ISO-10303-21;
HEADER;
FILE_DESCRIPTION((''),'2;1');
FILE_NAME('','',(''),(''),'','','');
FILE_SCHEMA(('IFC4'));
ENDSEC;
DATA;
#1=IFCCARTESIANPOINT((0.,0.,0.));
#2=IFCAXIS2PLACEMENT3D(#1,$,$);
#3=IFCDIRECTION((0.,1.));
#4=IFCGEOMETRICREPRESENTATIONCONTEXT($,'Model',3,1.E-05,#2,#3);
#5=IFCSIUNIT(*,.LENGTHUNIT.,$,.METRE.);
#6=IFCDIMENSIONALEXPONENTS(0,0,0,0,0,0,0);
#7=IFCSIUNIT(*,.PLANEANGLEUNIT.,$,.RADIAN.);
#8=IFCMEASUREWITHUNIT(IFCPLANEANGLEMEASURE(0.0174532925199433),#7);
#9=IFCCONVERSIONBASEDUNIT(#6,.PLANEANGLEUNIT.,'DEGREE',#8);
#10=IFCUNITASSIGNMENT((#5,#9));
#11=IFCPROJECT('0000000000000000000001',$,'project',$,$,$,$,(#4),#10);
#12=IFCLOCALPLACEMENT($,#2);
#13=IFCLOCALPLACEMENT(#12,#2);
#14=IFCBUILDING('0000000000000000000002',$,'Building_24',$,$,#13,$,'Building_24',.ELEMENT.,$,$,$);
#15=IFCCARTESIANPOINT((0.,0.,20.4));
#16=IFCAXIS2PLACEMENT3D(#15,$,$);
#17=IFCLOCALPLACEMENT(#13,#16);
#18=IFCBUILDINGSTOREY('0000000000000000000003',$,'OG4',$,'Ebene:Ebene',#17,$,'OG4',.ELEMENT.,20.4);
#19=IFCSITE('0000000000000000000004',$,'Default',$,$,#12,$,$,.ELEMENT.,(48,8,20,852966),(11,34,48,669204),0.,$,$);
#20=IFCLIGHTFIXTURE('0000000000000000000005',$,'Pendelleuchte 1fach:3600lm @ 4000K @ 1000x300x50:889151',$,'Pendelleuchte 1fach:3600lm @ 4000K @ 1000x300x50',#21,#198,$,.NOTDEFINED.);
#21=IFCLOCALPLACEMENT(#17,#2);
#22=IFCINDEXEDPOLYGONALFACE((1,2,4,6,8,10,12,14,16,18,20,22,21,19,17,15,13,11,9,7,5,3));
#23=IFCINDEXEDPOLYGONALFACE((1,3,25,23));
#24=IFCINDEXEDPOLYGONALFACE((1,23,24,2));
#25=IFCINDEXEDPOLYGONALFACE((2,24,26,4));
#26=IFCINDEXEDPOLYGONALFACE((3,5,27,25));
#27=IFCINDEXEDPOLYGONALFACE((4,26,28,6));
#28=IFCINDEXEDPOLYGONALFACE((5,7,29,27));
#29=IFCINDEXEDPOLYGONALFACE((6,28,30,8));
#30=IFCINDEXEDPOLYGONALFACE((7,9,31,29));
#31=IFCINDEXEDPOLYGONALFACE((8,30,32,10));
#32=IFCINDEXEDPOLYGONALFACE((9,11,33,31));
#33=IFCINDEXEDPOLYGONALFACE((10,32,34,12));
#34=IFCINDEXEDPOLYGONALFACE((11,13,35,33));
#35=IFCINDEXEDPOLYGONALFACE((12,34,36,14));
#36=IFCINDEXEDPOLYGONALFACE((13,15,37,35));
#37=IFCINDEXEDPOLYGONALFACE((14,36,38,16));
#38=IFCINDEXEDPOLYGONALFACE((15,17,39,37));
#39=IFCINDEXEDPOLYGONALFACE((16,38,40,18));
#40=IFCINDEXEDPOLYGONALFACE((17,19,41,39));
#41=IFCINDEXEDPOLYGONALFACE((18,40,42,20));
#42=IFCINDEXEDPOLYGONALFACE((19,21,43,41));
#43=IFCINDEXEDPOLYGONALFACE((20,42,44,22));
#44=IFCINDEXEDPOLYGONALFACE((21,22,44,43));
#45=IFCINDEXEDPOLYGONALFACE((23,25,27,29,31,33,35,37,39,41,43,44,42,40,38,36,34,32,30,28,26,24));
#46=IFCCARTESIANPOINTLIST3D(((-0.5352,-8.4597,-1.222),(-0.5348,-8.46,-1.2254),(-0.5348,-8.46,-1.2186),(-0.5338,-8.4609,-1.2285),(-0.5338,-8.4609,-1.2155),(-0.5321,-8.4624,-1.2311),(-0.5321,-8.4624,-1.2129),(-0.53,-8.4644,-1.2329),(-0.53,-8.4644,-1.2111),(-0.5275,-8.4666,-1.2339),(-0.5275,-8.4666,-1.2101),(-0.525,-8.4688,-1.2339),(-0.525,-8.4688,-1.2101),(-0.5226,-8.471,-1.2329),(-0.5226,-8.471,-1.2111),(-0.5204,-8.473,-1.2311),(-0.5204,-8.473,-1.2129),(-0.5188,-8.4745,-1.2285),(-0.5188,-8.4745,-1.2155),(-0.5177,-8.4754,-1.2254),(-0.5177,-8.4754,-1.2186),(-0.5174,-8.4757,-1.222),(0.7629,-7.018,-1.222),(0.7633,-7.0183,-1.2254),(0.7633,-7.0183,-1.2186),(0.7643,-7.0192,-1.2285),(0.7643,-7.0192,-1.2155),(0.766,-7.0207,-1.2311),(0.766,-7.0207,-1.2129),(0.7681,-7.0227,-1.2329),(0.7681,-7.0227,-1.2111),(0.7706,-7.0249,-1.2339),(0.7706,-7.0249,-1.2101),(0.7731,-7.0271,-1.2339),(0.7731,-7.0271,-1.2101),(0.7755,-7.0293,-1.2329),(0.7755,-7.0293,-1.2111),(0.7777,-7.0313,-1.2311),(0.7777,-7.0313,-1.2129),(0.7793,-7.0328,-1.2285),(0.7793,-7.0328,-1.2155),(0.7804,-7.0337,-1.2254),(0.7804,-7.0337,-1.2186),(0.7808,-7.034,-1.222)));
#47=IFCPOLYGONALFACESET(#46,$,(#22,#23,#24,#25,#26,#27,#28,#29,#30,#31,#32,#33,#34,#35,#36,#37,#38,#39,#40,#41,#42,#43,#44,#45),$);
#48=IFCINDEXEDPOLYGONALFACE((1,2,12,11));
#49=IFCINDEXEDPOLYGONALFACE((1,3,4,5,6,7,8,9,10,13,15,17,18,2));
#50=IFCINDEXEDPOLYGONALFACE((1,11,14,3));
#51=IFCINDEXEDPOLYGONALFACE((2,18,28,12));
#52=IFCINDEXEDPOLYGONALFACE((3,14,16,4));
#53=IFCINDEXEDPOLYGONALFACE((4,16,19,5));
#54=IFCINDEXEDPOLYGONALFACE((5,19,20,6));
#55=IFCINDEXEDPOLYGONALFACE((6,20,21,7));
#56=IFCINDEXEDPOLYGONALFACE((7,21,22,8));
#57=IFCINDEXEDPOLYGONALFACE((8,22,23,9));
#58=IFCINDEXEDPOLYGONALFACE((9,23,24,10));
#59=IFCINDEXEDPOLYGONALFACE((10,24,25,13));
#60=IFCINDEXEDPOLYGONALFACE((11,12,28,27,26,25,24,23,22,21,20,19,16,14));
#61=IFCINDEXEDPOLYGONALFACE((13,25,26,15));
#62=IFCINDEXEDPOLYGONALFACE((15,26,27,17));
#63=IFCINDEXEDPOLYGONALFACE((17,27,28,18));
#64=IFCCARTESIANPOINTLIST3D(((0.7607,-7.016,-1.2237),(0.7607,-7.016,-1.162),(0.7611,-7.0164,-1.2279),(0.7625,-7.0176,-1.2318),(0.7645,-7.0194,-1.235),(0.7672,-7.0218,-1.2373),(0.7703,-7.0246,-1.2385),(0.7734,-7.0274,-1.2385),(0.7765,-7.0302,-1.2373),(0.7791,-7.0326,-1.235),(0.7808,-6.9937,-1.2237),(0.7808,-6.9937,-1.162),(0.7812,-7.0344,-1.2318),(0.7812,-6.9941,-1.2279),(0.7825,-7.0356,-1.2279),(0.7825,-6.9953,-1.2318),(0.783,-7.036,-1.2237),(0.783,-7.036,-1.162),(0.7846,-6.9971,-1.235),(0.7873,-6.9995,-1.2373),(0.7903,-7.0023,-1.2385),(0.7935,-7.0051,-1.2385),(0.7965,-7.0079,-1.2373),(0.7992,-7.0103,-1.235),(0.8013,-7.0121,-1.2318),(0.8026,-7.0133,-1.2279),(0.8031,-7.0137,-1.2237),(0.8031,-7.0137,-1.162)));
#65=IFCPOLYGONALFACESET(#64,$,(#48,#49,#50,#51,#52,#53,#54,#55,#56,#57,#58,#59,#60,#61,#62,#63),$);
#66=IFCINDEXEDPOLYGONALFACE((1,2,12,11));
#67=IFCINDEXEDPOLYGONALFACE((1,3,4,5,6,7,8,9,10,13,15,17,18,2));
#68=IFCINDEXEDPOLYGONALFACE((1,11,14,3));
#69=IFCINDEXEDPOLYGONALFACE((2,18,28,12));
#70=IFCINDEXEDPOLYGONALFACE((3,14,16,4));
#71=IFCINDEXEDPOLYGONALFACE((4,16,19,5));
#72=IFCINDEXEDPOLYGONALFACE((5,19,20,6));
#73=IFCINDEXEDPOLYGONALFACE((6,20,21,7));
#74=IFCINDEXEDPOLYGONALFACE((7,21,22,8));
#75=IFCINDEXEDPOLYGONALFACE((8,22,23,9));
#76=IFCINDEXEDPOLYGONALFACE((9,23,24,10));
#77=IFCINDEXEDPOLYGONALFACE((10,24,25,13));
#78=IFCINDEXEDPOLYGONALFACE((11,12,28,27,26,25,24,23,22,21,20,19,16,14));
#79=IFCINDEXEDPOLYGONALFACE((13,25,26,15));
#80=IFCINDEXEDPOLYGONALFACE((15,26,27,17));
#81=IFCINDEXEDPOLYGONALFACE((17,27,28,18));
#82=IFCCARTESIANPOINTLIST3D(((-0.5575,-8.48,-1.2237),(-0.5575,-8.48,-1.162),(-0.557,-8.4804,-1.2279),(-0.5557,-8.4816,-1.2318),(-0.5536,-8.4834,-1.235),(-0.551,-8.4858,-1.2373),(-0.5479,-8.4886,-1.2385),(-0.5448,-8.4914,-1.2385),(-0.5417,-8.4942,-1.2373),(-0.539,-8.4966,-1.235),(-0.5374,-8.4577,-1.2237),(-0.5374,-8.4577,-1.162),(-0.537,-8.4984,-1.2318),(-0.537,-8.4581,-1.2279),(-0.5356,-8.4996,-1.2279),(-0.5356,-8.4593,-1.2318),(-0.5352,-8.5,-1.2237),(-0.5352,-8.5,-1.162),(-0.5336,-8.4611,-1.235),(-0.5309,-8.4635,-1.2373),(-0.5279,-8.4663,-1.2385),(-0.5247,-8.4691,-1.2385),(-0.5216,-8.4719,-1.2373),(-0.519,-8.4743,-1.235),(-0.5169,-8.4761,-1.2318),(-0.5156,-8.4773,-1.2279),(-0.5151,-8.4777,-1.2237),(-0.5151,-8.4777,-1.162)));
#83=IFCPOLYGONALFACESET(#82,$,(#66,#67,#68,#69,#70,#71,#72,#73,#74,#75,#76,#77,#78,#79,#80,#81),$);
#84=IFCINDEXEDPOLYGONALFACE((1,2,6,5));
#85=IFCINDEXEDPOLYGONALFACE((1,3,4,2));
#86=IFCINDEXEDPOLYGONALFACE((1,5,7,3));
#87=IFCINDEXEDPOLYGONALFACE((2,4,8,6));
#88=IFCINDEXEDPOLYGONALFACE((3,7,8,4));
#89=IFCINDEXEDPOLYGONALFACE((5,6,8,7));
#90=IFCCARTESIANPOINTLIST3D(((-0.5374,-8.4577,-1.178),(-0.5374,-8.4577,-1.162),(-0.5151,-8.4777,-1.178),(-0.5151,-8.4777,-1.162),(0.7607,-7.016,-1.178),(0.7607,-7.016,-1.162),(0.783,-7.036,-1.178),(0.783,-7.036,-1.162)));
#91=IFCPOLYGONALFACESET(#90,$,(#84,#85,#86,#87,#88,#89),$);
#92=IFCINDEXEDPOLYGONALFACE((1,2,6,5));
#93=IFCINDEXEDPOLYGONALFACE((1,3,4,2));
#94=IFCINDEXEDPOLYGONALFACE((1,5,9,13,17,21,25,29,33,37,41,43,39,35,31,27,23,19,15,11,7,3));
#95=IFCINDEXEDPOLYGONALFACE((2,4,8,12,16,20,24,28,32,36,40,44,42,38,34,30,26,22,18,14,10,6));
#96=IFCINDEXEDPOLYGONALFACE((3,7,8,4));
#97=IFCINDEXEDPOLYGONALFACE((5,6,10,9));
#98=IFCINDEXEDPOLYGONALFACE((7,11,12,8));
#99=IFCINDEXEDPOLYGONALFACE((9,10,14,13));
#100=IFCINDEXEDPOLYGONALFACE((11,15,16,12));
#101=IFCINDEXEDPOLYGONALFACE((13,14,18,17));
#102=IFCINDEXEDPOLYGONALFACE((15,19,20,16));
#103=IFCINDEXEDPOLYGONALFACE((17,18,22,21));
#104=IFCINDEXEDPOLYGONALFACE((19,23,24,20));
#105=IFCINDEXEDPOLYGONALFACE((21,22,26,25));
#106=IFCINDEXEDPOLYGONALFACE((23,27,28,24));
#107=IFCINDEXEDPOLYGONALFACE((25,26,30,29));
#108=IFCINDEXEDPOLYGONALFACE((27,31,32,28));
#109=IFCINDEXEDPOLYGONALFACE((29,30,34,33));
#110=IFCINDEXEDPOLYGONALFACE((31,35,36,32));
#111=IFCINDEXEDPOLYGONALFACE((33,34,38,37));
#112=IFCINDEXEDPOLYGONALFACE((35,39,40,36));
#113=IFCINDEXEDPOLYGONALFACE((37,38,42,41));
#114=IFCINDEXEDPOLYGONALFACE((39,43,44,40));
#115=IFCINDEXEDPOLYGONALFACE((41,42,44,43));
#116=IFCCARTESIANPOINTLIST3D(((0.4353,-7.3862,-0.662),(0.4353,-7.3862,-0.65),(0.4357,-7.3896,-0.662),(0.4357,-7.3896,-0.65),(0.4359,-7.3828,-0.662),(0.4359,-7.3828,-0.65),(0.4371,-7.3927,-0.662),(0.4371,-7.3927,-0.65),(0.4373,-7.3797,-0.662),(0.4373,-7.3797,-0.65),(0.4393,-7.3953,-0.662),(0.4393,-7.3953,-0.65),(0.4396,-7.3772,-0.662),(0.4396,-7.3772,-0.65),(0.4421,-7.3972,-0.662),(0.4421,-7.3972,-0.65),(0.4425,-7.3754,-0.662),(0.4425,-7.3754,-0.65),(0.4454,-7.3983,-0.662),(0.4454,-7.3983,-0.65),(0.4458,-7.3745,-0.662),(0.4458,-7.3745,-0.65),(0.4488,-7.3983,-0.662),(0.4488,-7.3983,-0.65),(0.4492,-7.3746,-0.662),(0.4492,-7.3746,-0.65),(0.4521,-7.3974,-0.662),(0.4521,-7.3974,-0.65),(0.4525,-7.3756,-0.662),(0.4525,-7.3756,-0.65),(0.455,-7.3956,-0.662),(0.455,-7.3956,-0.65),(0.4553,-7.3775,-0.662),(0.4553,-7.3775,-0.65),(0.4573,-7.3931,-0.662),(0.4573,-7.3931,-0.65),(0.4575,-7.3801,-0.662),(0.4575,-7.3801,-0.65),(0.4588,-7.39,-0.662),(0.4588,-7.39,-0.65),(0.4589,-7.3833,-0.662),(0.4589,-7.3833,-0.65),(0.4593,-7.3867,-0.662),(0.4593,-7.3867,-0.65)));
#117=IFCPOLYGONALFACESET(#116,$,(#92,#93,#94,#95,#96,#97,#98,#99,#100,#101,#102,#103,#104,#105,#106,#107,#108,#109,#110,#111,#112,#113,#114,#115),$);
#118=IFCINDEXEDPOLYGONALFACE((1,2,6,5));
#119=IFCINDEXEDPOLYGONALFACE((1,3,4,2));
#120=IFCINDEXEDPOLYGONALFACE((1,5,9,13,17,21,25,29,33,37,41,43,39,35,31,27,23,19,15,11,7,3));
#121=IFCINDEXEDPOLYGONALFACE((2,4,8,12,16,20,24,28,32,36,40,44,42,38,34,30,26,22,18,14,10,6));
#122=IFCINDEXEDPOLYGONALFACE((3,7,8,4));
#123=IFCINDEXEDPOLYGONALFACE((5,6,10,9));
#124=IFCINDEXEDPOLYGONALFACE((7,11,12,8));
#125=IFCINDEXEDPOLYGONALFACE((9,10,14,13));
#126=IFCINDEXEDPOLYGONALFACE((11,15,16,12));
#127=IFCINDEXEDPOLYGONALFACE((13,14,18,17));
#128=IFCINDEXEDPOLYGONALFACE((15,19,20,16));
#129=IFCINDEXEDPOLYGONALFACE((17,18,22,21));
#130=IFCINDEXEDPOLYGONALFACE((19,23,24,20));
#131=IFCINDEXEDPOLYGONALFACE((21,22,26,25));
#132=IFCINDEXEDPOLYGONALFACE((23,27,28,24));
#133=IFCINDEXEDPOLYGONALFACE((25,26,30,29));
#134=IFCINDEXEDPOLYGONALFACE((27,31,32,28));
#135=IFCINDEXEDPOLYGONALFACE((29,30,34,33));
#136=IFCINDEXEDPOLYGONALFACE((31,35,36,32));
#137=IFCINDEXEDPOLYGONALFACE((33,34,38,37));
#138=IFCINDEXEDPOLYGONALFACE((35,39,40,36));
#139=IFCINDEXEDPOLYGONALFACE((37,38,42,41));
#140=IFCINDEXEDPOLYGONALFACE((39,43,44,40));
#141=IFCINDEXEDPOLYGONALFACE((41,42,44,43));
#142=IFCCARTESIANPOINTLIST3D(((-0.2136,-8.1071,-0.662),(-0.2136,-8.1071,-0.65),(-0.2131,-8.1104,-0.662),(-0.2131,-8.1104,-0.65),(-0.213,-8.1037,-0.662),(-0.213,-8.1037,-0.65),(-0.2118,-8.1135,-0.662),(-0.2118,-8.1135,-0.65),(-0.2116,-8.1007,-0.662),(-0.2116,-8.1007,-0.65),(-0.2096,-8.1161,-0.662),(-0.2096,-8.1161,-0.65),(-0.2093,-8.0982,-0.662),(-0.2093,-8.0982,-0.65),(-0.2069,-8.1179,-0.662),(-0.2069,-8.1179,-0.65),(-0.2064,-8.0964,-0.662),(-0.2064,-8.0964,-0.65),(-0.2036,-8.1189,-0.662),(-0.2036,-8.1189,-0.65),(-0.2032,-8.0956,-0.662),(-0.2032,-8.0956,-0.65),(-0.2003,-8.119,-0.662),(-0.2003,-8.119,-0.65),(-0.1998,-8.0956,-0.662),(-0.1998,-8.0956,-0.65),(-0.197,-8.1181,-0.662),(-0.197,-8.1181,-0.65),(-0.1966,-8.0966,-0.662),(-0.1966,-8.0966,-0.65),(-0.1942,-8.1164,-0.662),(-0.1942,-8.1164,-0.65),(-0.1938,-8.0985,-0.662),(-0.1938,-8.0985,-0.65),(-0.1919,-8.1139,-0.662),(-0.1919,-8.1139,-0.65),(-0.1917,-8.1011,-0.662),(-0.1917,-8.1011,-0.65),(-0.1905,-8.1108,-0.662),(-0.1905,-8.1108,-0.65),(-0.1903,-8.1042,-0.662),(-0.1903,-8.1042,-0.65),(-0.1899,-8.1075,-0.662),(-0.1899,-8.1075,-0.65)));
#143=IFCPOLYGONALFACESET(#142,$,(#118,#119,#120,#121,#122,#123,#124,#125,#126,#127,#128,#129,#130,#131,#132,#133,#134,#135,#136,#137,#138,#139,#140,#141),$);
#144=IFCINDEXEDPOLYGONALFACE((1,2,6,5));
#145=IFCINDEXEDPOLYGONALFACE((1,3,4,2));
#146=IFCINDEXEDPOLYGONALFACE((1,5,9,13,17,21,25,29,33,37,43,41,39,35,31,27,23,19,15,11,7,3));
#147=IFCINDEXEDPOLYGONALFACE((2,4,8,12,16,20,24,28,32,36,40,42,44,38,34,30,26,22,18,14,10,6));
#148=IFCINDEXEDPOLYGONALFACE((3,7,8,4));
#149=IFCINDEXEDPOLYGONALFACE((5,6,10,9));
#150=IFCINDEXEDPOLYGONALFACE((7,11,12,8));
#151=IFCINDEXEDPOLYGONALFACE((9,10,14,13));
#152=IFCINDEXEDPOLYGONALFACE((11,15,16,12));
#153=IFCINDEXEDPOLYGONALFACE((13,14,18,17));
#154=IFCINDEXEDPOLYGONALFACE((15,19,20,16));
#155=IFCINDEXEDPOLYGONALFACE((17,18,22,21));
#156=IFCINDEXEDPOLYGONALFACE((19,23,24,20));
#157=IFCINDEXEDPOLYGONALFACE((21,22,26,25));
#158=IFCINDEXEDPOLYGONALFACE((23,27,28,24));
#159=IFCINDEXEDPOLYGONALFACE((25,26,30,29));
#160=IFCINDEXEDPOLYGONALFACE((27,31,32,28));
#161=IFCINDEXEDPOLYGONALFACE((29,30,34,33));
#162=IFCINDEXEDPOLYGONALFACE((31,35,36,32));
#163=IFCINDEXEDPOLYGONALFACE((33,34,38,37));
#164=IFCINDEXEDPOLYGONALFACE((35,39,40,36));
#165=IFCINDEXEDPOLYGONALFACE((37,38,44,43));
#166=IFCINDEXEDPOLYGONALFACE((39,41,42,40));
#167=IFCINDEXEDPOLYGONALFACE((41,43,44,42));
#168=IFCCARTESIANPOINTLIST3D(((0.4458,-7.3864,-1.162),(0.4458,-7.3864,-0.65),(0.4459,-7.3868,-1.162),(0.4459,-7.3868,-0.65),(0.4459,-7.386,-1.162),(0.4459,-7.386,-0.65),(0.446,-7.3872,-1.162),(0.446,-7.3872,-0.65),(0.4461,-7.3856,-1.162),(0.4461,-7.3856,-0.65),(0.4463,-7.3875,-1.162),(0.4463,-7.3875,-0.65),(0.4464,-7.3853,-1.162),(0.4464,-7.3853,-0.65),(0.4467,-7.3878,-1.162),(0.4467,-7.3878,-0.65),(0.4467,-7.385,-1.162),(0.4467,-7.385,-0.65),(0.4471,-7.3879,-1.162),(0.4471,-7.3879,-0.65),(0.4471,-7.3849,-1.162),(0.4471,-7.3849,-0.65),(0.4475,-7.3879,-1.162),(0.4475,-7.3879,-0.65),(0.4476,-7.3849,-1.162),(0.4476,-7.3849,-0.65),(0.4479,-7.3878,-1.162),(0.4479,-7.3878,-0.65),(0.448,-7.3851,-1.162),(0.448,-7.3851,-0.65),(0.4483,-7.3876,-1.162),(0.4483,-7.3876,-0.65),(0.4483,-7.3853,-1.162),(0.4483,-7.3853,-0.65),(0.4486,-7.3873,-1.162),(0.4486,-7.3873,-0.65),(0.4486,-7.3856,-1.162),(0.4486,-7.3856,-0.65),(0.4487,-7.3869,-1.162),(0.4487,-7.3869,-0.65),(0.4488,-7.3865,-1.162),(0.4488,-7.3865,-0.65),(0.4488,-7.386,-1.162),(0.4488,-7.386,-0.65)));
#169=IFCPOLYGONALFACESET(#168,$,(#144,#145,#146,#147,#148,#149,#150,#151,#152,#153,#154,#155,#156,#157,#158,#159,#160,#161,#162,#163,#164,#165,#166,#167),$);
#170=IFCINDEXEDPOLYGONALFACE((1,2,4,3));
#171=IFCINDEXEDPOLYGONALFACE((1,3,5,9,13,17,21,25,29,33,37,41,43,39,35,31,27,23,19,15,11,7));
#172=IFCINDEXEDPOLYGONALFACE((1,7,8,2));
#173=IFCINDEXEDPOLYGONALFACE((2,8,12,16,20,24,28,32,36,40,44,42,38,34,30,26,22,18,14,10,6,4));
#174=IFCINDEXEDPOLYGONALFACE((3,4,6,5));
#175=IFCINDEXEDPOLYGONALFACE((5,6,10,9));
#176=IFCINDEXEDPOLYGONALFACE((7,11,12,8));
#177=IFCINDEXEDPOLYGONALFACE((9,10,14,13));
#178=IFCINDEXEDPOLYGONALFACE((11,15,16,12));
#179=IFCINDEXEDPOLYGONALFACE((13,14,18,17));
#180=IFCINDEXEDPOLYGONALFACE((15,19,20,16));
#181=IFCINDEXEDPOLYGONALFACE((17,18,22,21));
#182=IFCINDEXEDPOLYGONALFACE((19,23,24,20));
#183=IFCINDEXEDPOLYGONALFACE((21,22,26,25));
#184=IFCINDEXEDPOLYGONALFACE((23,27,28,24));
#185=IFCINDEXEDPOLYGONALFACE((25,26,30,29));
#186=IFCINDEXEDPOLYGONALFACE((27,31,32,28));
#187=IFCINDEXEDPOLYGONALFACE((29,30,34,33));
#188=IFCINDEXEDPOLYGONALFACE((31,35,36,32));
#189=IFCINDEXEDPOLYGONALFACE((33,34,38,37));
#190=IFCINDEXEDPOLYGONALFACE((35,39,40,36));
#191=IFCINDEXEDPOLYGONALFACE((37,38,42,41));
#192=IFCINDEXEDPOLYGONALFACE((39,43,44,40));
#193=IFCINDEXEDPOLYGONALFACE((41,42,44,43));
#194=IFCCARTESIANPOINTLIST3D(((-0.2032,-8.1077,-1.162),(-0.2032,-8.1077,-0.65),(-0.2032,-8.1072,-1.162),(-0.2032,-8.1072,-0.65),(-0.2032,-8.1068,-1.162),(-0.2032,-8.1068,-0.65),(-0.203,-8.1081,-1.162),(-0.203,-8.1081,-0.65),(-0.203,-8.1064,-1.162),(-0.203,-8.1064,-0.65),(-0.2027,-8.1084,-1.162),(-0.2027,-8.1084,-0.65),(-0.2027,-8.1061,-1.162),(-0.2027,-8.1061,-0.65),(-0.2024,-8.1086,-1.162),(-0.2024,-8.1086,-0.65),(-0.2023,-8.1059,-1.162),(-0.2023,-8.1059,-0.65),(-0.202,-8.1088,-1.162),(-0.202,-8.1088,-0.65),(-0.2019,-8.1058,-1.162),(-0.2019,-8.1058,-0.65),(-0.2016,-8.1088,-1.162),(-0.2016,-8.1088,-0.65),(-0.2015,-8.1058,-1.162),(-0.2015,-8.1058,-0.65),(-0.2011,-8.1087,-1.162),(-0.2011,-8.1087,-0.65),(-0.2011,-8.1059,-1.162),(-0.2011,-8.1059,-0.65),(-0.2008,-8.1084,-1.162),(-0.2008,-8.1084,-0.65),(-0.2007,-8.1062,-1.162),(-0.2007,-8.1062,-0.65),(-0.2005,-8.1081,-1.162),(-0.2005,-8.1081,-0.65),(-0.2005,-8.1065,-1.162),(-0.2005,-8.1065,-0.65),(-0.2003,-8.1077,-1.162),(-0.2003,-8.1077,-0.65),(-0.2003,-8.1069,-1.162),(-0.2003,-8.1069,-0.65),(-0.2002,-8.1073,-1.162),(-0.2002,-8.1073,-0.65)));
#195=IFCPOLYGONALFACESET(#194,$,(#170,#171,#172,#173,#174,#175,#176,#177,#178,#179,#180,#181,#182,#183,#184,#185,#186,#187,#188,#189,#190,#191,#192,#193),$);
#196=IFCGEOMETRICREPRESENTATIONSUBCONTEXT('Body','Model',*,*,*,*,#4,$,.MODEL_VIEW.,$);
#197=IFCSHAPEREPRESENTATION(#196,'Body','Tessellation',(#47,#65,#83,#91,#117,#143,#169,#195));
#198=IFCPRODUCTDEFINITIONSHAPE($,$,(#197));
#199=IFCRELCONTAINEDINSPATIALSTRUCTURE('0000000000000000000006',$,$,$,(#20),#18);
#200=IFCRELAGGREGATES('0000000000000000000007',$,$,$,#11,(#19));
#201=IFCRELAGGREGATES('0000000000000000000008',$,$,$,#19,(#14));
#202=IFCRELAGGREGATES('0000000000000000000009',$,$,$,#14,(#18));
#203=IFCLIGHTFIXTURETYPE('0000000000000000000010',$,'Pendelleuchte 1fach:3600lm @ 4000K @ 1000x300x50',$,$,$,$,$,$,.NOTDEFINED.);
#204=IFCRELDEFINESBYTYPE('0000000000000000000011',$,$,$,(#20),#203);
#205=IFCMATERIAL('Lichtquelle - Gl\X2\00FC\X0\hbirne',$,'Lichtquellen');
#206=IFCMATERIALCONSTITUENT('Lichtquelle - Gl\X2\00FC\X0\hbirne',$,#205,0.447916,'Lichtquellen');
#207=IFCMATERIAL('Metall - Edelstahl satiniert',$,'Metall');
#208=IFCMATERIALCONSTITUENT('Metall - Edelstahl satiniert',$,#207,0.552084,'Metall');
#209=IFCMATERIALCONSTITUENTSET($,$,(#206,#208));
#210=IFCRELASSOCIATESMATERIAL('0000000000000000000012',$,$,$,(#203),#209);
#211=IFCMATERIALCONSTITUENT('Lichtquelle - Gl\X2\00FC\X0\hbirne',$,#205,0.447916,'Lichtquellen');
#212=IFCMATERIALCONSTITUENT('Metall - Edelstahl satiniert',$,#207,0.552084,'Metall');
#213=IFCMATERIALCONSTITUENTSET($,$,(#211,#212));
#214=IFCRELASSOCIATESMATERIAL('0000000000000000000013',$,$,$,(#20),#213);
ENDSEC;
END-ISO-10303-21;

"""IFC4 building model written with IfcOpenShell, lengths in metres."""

from ifc_helpers import new_model, entity, si_unit, converted_unit, direction, frame, origin, place, context, subcontext, project, spatial, line, arc, indexed_curve, outline, extrude, source, transform, mapped, material, constituent, constituent_set, type_object, type_shapes, element, save


model = new_model("IFC4")

# Units and contexts
model_context = context("Model", 3, precision=1e-05, world=origin(), true_north=direction((0.0, 1.0)))
body_context = subcontext(model_context, "Body", "Model", "MODEL_VIEW")
ifc_project = project(units=[si_unit("LENGTHUNIT", "METRE"), converted_unit("PLANEANGLEUNIT", "DEGREE", entity("IfcPlaneAngleMeasure", 0.0174532925199433), si_unit("PLANEANGLEUNIT", "RADIAN"), dimensions=[0, 0, 0, 0, 0, 0, 0])], contexts=[model_context])

# Site, building, storey
site_placement = place(None, origin())
site = spatial("IfcSite", under=ifc_project, at=site_placement, Name="Default", CompositionType="ELEMENT", RefLatitude=(48, 8, 20, 852966), RefLongitude=(11, 34, 48, 669204), RefElevation=0.0)
building_placement = place(site_placement, origin())
building = spatial("IfcBuilding", under=site, at=building_placement, Name="Building_24", LongName="Building_24", CompositionType="ELEMENT")
storey_placement = place(building_placement, frame((0.0, 0.0, 20.4)))
storey = spatial("IfcBuildingStorey", under=building, at=storey_placement, Name="OG4", ObjectType="Ebene:Ebene", LongName="OG4", CompositionType="ELEMENT", Elevation=20.4)

# Light fixture
ifc_material_1 = material(Name="Lichtquelle - Glühbirne", Category="Lichtquellen")
ifc_material_2 = material(Name="Metall - Edelstahl satiniert", Category="Metall")
ifc_constituent_1 = constituent(ifc_material_1, Name="Lichtquelle - Glühbirne", Category="Lichtquellen", fraction=0.447916)
ifc_constituent_2 = constituent(ifc_material_2, Name="Metall - Edelstahl satiniert", Category="Metall", fraction=0.552084)
ifc_constituent_set_1 = constituent_set(constituents=[ifc_constituent_1, ifc_constituent_2])
light_fixture_type = type_object("IfcLightFixtureType", Name="Pendelleuchte 1fach:3600lm @ 4000K @ 1000x300x50", PredefinedType="NOTDEFINED", material=ifc_constituent_set_1)
shared_shape_1 = source(origin(), body_context, "Body", "SweptSolid", [
    extrude(outline(indexed_curve([(-0.012, 0.0), (0.0, -0.012), (0.012, 0.0), (0.0, 0.012)], segments=[arc(1, 2, 3), arc(3, 4, 1)], self_intersect=False)), frame((-0.97, 0.0, -0.572), z_axis=(1.0, 0.0, 0.0), x_axis=(0.0, 1.0, 0.0)), (0.0, 0.0, 1.0), 1.94),
    extrude(outline(indexed_curve([(-0.0308, -0.015), (0.0308, -0.015), (0.0308, 0.015), (-0.0308, 0.015), (-0.0458, 0.0)], segments=[line(1, 2, 3, 4), arc(4, 5, 1)], self_intersect=False)), frame((0.97, 0.0, -0.5428), z_axis=(1.0, 0.0, 0.0), x_axis=(0.0, 0.0, 1.0)), (0.0, 0.0, 1.0), 0.03),
    extrude(outline(indexed_curve([(-0.0308, -0.015), (0.0308, -0.015), (0.0308, 0.015), (-0.0308, 0.015), (-0.0458, 0.0)], segments=[line(1, 2, 3, 4), arc(4, 5, 1)], self_intersect=False)), frame((-1.0, 0.0, -0.5428), z_axis=(1.0, 0.0, 0.0), x_axis=(0.0, 0.0, 1.0)), (0.0, 0.0, 1.0), 0.03),
    extrude(outline(indexed_curve([(-0.97, -0.015), (0.97, -0.015), (0.97, 0.015), (-0.97, 0.015), (-0.97, -0.015)], self_intersect=False)), frame((0.0, 0.0, -0.528), z_axis=(0.0, 0.0, 1.0), x_axis=(-1.0, 0.0, 0.0)), (0.0, 0.0, 1.0), 0.016),
    extrude(outline(indexed_curve([(-0.012, 0.0), (0.0, -0.012), (0.012, 0.0), (0.0, 0.012)], segments=[arc(1, 2, 3), arc(3, 4, 1)], self_intersect=False)), frame((0.485, 0.0, -0.012)), (0.0, 0.0, 1.0), 0.012),
    extrude(outline(indexed_curve([(-0.0118, 0.0), (0.0, -0.0118), (0.0118, 0.0), (0.0, 0.0118)], segments=[arc(1, 2, 3), arc(3, 4, 1)], self_intersect=False)), frame((-0.485, 0.0, -0.012)), (0.0, 0.0, 1.0), 0.012),
    extrude(outline(indexed_curve([(-0.0015, 0.0), (0.0, -0.0015), (0.0015, 0.0), (0.0, 0.0015)], segments=[arc(1, 2, 3), arc(3, 4, 1)], self_intersect=False)), frame((0.485, 0.0, -0.512)), (0.0, 0.0, 1.0), 0.512),
    extrude(outline(indexed_curve([(-0.0015, 0.0), (0.0, -0.0015), (0.0015, 0.0), (0.0, 0.0015)], segments=[arc(1, 2, 3), arc(3, 4, 1)], self_intersect=False)), frame((-0.485, 0.0, -0.512)), (0.0, 0.0, 1.0), 0.512),
])
type_shapes(light_fixture_type, [shared_shape_1])
ifc_constituent_3 = constituent(ifc_material_1, Name="Lichtquelle - Glühbirne", Category="Lichtquellen", fraction=0.447916)
ifc_constituent_4 = constituent(ifc_material_2, Name="Metall - Edelstahl satiniert", Category="Metall", fraction=0.552084)
ifc_constituent_set_2 = constituent_set(constituents=[ifc_constituent_3, ifc_constituent_4])
light_fixture_1_placement = place(storey_placement, frame((0.1228, -7.7469, -0.65), z_axis=(0.0, 0.0, 1.0), x_axis=(0.669131, 0.743145, 0.0)))
element("IfcLightFixture", 1, at=light_fixture_1_placement, inside=storey, type_object=light_fixture_type, material=ifc_constituent_set_2, Name="Pendelleuchte 1fach:3600lm @ 4000K @ 1000x300x50:889151", ObjectType="Pendelleuchte 1fach:3600lm @ 4000K @ 1000x300x50", PredefinedType="NOTDEFINED", context=body_context, shape_type="MappedRepresentation", body=[
    mapped(shared_shape_1, transform((0.0, 0.0, 0.0), scale=1.0)),
])

save(model, "model.ifc")
